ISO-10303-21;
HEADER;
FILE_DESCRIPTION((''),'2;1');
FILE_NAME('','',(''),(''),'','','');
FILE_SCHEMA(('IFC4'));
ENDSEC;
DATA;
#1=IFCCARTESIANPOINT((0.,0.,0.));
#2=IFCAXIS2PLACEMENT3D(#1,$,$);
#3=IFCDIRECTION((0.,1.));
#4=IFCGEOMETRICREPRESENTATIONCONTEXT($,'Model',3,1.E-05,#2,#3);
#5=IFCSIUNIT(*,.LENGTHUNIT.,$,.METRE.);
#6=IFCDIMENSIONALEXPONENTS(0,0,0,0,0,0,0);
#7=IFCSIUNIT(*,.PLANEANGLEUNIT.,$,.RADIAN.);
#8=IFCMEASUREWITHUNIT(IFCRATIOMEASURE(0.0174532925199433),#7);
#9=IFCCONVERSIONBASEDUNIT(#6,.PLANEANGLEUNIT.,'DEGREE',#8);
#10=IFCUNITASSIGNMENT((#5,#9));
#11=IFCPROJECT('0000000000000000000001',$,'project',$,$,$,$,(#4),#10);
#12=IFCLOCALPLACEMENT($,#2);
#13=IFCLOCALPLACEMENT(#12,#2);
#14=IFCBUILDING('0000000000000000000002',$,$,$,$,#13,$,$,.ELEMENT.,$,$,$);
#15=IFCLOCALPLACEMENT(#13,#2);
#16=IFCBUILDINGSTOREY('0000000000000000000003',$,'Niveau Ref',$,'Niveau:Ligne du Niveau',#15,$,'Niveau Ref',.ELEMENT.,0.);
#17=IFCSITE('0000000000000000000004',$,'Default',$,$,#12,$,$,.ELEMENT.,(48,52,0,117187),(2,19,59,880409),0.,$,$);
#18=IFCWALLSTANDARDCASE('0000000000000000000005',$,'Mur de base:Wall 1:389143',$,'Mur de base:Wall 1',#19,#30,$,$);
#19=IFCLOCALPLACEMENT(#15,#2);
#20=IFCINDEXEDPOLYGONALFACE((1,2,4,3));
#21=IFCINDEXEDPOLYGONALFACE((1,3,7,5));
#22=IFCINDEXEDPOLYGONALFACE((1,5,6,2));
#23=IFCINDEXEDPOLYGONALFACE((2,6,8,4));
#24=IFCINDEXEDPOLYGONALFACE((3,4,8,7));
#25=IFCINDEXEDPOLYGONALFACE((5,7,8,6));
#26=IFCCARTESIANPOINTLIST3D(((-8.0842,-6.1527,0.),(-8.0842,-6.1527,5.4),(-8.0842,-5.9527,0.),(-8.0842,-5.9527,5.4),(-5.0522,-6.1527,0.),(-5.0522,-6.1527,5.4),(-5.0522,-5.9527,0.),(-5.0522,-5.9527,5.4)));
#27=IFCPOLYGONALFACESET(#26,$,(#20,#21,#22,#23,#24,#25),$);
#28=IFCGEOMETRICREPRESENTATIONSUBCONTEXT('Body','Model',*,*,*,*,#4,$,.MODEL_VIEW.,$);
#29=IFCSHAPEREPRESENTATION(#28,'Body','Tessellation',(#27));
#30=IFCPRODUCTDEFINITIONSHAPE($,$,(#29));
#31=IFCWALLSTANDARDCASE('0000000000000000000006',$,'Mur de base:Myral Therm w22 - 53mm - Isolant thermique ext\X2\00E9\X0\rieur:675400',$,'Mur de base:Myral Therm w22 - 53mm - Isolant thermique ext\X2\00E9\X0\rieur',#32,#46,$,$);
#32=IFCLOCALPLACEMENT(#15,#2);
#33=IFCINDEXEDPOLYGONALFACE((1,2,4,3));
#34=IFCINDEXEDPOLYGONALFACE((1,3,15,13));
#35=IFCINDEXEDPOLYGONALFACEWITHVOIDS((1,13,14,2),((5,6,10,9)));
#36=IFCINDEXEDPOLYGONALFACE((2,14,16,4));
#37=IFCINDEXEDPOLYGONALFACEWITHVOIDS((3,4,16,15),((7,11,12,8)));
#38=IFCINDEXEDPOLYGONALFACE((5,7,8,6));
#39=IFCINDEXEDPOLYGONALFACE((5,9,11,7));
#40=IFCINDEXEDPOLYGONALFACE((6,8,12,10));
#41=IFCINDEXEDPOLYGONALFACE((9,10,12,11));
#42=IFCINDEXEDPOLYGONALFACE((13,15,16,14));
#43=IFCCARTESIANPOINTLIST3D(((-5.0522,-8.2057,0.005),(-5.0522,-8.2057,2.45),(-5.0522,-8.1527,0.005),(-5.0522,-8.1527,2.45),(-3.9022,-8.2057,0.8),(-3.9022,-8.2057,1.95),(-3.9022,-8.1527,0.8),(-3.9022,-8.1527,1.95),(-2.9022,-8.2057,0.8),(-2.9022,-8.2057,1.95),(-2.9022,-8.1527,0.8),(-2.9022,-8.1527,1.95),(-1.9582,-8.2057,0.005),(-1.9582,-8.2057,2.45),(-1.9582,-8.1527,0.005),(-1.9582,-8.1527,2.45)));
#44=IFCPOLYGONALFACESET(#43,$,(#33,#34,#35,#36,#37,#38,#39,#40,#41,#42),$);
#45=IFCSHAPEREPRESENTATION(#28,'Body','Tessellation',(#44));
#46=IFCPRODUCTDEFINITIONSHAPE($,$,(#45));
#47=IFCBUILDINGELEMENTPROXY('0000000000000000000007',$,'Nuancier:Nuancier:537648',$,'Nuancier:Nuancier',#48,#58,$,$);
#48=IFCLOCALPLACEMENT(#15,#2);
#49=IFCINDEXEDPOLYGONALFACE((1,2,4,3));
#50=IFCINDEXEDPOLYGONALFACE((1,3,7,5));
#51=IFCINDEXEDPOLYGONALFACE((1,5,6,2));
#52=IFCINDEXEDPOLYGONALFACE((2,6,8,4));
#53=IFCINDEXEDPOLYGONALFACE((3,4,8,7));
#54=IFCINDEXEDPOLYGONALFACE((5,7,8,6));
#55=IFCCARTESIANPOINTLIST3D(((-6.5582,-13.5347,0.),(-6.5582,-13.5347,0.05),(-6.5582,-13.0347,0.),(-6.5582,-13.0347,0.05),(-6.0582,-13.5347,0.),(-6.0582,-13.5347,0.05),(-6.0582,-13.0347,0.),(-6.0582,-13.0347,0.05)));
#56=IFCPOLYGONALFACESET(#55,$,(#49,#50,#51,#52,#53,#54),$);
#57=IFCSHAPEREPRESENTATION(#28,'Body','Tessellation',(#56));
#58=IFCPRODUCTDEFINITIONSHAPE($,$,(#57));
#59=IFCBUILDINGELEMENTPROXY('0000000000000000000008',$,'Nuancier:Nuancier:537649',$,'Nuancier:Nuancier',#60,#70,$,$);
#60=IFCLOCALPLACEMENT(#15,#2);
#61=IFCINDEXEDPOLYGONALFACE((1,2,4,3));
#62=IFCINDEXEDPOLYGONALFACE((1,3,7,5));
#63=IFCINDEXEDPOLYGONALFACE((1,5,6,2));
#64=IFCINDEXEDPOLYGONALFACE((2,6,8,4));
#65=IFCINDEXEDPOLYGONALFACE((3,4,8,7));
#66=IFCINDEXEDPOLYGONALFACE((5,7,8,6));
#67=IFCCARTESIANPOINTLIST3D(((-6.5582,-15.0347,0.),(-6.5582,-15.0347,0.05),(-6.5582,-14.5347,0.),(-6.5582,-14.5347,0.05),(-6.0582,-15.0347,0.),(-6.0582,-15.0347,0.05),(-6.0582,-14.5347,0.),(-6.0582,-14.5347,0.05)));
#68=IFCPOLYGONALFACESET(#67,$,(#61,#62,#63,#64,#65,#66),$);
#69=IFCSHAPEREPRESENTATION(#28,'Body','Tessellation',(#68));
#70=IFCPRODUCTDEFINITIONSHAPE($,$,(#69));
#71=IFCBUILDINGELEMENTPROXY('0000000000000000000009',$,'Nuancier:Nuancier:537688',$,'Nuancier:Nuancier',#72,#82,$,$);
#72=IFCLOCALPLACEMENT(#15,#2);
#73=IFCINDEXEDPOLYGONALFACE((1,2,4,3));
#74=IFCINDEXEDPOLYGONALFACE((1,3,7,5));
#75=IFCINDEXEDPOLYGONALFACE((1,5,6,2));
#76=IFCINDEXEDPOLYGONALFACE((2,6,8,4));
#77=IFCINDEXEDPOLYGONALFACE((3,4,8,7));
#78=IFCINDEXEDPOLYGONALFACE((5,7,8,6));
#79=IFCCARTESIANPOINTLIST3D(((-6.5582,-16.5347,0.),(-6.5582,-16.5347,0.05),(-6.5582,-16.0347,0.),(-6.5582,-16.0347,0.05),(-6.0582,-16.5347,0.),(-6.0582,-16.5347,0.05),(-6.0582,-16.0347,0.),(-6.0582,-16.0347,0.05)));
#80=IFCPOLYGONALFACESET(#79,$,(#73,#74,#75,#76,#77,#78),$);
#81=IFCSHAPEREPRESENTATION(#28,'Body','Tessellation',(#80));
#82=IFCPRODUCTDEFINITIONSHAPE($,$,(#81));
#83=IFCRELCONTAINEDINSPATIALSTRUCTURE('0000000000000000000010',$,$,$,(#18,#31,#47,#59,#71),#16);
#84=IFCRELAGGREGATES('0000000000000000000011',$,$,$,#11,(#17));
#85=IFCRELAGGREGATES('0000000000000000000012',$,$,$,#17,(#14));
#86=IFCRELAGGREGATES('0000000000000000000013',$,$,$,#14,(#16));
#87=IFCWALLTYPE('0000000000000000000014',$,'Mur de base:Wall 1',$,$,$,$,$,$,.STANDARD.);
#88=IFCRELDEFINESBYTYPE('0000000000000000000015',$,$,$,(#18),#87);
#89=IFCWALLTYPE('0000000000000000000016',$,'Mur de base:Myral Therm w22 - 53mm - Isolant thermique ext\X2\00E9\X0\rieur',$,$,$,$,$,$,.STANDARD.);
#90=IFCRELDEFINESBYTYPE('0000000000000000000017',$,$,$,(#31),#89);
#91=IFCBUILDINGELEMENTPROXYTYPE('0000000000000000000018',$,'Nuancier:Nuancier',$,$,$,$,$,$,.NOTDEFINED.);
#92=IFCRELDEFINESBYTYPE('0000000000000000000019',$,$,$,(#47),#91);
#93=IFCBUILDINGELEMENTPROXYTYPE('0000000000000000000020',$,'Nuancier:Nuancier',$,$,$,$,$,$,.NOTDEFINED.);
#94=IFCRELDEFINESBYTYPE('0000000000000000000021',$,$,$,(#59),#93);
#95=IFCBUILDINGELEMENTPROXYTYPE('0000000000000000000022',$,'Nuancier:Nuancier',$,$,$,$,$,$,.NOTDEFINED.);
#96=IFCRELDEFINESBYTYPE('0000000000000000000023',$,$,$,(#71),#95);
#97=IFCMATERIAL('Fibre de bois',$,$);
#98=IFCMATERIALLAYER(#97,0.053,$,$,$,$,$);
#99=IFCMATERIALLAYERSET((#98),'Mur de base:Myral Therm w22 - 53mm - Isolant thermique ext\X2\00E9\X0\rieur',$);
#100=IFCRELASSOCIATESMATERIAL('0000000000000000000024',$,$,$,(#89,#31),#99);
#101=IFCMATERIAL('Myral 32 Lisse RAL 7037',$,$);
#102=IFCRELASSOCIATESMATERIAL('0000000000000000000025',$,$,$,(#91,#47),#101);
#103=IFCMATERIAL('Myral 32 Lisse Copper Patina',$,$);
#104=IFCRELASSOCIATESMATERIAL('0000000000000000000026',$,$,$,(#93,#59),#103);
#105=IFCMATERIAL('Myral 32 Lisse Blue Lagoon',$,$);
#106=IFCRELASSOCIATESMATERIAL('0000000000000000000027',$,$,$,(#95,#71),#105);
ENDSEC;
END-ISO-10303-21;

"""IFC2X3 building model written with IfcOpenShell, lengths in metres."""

from ifc_helpers import new_model, entity, si_unit, converted_unit, direction, frame, frame_2d, origin, origin_2d_with_axis, place, context, subcontext, project, spatial, rectangle, extrude, source, transform, mapped, material, layer, layer_set, layer_usage, type_object, type_shapes, element, save


model = new_model("IFC2X3")

# Units and contexts
model_context = context("Model", 3, precision=1e-05, world=origin(), true_north=direction((0.0, 1.0)))
body_context = subcontext(model_context, "Body", "Model", "MODEL_VIEW")
ifc_project = project(units=[si_unit("LENGTHUNIT", "METRE"), converted_unit("PLANEANGLEUNIT", "DEGREE", entity("IfcRatioMeasure", 0.0174532925199433), si_unit("PLANEANGLEUNIT", "RADIAN"), dimensions=[0, 0, 0, 0, 0, 0, 0])], contexts=[model_context])

# Site, building, storey
site_placement = place(None, origin())
site = spatial("IfcSite", under=ifc_project, at=site_placement, Name="Default", CompositionType="ELEMENT", RefLatitude=(48, 52, 0, 117187), RefLongitude=(2, 19, 59, 880409), RefElevation=0.0)
building_placement = place(site_placement, origin())
building = spatial("IfcBuilding", under=site, at=building_placement, CompositionType="ELEMENT")
storey_placement = place(building_placement, origin())
storey = spatial("IfcBuildingStorey", under=building, at=storey_placement, Name="Niveau Ref", ObjectType="Niveau:Ligne du Niveau", LongName="Niveau Ref", CompositionType="ELEMENT", Elevation=0.0)

# Wall
wall_type_1 = type_object("IfcWallType", Name="Mur de base:Wall 1", PredefinedType="STANDARD")
wall_1_placement = place(storey_placement, frame((-5.0522, -6.0527, 0.0), z_axis=(0.0, 0.0, 1.0), x_axis=(-1.0, 0.0, 0.0)))
element("IfcWallStandardCase", 1, at=wall_1_placement, inside=storey, type_object=wall_type_1, Name="Mur de base:Wall 1:389143", ObjectType="Mur de base:Wall 1", context=body_context, shape_type="SweptSolid", body=[
    extrude(rectangle(XDim=3.032, YDim=0.2, at=frame_2d((1.516, 0.0), x_axis=(-1.0, 0.0))), origin(), (0.0, 0.0, 1.0), 5.4),
])

# Wall, opening
ifc_material_1 = material(Name="Fibre de bois")
ifc_layer = layer(ifc_material_1, 0.053)
ifc_layer_set = layer_set([ifc_layer], Name="Mur de base:Myral Therm w22 - 53mm - Isolant thermique extérieur")
ifc_layer_usage = layer_usage(ifc_layer_set, "AXIS2", "NEGATIVE", 0.0265)
wall_type_2 = type_object("IfcWallType", Name="Mur de base:Myral Therm w22 - 53mm - Isolant thermique extérieur", PredefinedType="STANDARD", material=ifc_layer_set)
wall_2_placement = place(storey_placement, frame((-5.0522, -8.1792, 0.005)))
wall_2 = element("IfcWallStandardCase", 2, at=wall_2_placement, inside=storey, type_object=wall_type_2, material=ifc_layer_usage, Name="Mur de base:Myral Therm w22 - 53mm - Isolant thermique extérieur:675400", ObjectType="Mur de base:Myral Therm w22 - 53mm - Isolant thermique extérieur", context=body_context, shape_type="SweptSolid", body=[
    extrude(rectangle(XDim=3.094, YDim=0.053, at=frame_2d((1.547, 0.0), x_axis=(-1.0, 0.0))), origin(), (0.0, 0.0, 1.0), 2.445),
])
opening_placement = place(wall_2_placement, origin())
element("IfcOpeningElement", 3, at=opening_placement, cuts=wall_2, ObjectType="Opening", context=body_context, shape_type="SweptSolid", body=[
    extrude(rectangle(XDim=1.15, YDim=1.0, at=frame_2d((0.0, 0.0), x_axis=(0.0, 1.0))), frame((1.65, 0.0265, 1.37), z_axis=(0.0, -1.0, 0.0), x_axis=(-1.0, 0.0, 0.0)), (0.0, 0.0, 1.0), 0.053),
])

# Building element proxies
ifc_material_2 = material(Name="Myral 32 Lisse RAL 7037")
building_element_proxy_type_1 = type_object("IfcBuildingElementProxyType", Name="Nuancier:Nuancier", PredefinedType="NOTDEFINED", material=ifc_material_2)
shared_shape_1 = source(origin(), body_context, "Body", "SweptSolid", [
    extrude(rectangle(XDim=0.5, YDim=0.5, at=origin_2d_with_axis()), frame((0.0, 0.0, 0.0), z_axis=(0.0, 0.0, 1.0), x_axis=(-1.0, 0.0, 0.0)), (0.0, 0.0, 1.0), 0.05),
])
type_shapes(building_element_proxy_type_1, [shared_shape_1])
proxy_1_placement = place(storey_placement, frame((-6.3082, -13.2847, 0.0)))
element("IfcBuildingElementProxy", 4, at=proxy_1_placement, inside=storey, type_object=building_element_proxy_type_1, material=ifc_material_2, Name="Nuancier:Nuancier:537648", ObjectType="Nuancier:Nuancier", context=body_context, shape_type="MappedRepresentation", body=[
    mapped(shared_shape_1, transform((0.0, 0.0, 0.0), scale=1.0)),
])
ifc_material_3 = material(Name="Myral 32 Lisse Copper Patina")
building_element_proxy_type_2 = type_object("IfcBuildingElementProxyType", Name="Nuancier:Nuancier", PredefinedType="NOTDEFINED", material=ifc_material_3)
shared_shape_2 = source(origin(), body_context, "Body", "SweptSolid", [
    extrude(rectangle(XDim=0.5, YDim=0.5, at=origin_2d_with_axis()), frame((0.0, 0.0, 0.0), z_axis=(0.0, 0.0, 1.0), x_axis=(-1.0, 0.0, 0.0)), (0.0, 0.0, 1.0), 0.05),
])
type_shapes(building_element_proxy_type_2, [shared_shape_2])
proxy_2_placement = place(storey_placement, frame((-6.3082, -14.7847, 0.0)))
element("IfcBuildingElementProxy", 5, at=proxy_2_placement, inside=storey, type_object=building_element_proxy_type_2, material=ifc_material_3, Name="Nuancier:Nuancier:537649", ObjectType="Nuancier:Nuancier", context=body_context, shape_type="MappedRepresentation", body=[
    mapped(shared_shape_2, transform((0.0, 0.0, 0.0), scale=1.0)),
])
ifc_material_4 = material(Name="Myral 32 Lisse Blue Lagoon")
building_element_proxy_type_3 = type_object("IfcBuildingElementProxyType", Name="Nuancier:Nuancier", PredefinedType="NOTDEFINED", material=ifc_material_4)
shared_shape_3 = source(origin(), body_context, "Body", "SweptSolid", [
    extrude(rectangle(XDim=0.5, YDim=0.5, at=origin_2d_with_axis()), frame((0.0, 0.0, 0.0), z_axis=(0.0, 0.0, 1.0), x_axis=(-1.0, 0.0, 0.0)), (0.0, 0.0, 1.0), 0.05),
])
type_shapes(building_element_proxy_type_3, [shared_shape_3])
proxy_3_placement = place(storey_placement, frame((-6.3082, -16.2847, 0.0)))
element("IfcBuildingElementProxy", 6, at=proxy_3_placement, inside=storey, type_object=building_element_proxy_type_3, material=ifc_material_4, Name="Nuancier:Nuancier:537688", ObjectType="Nuancier:Nuancier", context=body_context, shape_type="MappedRepresentation", body=[
    mapped(shared_shape_3, transform((0.0, 0.0, 0.0), scale=1.0)),
])

save(model, "model.ifc")
